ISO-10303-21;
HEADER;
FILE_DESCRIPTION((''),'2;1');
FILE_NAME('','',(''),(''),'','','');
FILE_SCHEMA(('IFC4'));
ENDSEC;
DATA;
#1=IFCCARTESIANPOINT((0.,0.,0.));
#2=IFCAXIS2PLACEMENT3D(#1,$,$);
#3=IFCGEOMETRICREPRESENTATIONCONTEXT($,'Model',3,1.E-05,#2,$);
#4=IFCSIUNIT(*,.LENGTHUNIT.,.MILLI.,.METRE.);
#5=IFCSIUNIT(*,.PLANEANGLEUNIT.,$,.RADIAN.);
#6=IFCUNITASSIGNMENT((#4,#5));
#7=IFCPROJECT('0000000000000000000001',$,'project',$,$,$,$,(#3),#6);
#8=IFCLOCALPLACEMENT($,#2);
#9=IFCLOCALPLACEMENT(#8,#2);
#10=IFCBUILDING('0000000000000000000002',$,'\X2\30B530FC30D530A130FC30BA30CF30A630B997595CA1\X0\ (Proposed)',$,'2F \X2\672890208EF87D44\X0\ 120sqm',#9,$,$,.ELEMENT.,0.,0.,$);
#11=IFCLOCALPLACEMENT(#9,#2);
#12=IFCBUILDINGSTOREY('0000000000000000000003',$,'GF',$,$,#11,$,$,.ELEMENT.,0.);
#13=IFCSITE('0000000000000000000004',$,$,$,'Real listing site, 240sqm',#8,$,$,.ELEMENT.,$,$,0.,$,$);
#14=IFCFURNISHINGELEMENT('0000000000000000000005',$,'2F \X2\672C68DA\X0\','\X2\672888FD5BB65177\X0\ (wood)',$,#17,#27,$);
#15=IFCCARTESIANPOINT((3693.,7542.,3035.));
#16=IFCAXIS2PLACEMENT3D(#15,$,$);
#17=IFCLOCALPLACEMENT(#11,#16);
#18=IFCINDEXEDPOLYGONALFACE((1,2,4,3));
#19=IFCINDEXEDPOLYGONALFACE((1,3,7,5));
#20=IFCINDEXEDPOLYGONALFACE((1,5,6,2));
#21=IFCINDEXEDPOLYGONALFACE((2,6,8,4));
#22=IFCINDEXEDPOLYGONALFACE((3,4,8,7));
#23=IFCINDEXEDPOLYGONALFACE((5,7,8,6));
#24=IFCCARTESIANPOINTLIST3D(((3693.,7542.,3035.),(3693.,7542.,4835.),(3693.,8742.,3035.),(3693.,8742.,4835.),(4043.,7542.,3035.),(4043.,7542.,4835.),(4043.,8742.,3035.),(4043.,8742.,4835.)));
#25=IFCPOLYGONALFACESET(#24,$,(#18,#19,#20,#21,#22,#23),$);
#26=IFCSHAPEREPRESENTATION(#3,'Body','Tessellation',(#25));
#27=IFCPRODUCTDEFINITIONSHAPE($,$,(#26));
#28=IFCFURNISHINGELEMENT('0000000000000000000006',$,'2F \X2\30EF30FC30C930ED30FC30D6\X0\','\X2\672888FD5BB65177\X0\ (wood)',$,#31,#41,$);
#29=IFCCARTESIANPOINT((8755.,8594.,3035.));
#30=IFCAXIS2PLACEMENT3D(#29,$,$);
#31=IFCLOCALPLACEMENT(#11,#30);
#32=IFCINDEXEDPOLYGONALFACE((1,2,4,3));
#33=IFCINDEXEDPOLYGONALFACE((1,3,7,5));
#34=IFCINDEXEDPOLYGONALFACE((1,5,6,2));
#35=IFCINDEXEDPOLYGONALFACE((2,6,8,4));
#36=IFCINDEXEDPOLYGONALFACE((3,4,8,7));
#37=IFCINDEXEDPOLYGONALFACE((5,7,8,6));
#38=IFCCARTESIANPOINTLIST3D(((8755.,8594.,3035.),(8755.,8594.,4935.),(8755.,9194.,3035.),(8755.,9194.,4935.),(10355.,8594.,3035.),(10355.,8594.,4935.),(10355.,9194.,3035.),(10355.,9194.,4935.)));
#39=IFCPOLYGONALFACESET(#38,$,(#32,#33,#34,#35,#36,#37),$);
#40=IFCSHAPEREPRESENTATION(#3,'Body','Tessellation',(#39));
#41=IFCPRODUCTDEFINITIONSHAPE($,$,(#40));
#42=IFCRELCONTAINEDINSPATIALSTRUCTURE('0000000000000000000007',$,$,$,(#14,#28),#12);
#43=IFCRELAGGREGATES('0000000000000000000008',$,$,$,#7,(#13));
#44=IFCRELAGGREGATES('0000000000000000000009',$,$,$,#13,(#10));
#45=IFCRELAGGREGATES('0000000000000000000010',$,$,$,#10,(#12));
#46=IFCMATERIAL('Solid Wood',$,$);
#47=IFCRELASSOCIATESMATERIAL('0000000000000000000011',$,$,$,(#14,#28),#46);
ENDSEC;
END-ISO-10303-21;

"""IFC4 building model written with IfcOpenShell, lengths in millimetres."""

from ifc_helpers import new_model, si_unit, frame, frame_2d, origin, place, context, project, spatial, rectangle, extrude, material, element, save


model = new_model("IFC4")

# Units and contexts
model_context = context("Model", 3, precision=1e-05, world=origin())
ifc_project = project(units=[si_unit("LENGTHUNIT", "METRE", prefix="MILLI"), si_unit("PLANEANGLEUNIT", "RADIAN")], contexts=[model_context])

# Site, building, storey
site_placement = place(None, origin())
site = spatial("IfcSite", under=ifc_project, at=site_placement, ObjectType="Real listing site, 240sqm", CompositionType="ELEMENT", RefElevation=0.0)
building_placement = place(site_placement, origin())
building = spatial("IfcBuilding", under=site, at=building_placement, Name="サーファーズハウス静岡 (Proposed)", ObjectType="2F 木造軸組 120sqm", CompositionType="ELEMENT", ElevationOfRefHeight=0.0, ElevationOfTerrain=0.0)
storey_placement = place(building_placement, origin())
storey = spatial("IfcBuildingStorey", under=building, at=storey_placement, Name="GF", CompositionType="ELEMENT", Elevation=0.0)

# Shared definitions
ifc_material_1 = material(Name="Solid Wood")

# Furnishing elements
furnishing_1_placement = place(storey_placement, frame((3693.0, 7542.0, 3035.0)))
element("IfcFurnishingElement", 1, at=furnishing_1_placement, inside=storey, material=ifc_material_1, Name="2F 本棚", Description="木製家具 (wood)", context=model_context, shape_type="SweptSolid", body=[
    extrude(rectangle(XDim=350.0, YDim=1200.0, at=frame_2d((175.0, 600.0))), frame((3693.0, 7542.0, 3035.0)), (0.0, 0.0, 1.0), 1800.0),
])
furnishing_2_placement = place(storey_placement, frame((8755.0, 8594.0, 3035.0)))
element("IfcFurnishingElement", 2, at=furnishing_2_placement, inside=storey, material=ifc_material_1, Name="2F ワードローブ", Description="木製家具 (wood)", context=model_context, shape_type="SweptSolid", body=[
    extrude(rectangle(XDim=1600.0, YDim=600.0, at=frame_2d((800.0, 300.0))), frame((8755.0, 8594.0, 3035.0)), (0.0, 0.0, 1.0), 1900.0),
])

save(model, "model.ifc")
